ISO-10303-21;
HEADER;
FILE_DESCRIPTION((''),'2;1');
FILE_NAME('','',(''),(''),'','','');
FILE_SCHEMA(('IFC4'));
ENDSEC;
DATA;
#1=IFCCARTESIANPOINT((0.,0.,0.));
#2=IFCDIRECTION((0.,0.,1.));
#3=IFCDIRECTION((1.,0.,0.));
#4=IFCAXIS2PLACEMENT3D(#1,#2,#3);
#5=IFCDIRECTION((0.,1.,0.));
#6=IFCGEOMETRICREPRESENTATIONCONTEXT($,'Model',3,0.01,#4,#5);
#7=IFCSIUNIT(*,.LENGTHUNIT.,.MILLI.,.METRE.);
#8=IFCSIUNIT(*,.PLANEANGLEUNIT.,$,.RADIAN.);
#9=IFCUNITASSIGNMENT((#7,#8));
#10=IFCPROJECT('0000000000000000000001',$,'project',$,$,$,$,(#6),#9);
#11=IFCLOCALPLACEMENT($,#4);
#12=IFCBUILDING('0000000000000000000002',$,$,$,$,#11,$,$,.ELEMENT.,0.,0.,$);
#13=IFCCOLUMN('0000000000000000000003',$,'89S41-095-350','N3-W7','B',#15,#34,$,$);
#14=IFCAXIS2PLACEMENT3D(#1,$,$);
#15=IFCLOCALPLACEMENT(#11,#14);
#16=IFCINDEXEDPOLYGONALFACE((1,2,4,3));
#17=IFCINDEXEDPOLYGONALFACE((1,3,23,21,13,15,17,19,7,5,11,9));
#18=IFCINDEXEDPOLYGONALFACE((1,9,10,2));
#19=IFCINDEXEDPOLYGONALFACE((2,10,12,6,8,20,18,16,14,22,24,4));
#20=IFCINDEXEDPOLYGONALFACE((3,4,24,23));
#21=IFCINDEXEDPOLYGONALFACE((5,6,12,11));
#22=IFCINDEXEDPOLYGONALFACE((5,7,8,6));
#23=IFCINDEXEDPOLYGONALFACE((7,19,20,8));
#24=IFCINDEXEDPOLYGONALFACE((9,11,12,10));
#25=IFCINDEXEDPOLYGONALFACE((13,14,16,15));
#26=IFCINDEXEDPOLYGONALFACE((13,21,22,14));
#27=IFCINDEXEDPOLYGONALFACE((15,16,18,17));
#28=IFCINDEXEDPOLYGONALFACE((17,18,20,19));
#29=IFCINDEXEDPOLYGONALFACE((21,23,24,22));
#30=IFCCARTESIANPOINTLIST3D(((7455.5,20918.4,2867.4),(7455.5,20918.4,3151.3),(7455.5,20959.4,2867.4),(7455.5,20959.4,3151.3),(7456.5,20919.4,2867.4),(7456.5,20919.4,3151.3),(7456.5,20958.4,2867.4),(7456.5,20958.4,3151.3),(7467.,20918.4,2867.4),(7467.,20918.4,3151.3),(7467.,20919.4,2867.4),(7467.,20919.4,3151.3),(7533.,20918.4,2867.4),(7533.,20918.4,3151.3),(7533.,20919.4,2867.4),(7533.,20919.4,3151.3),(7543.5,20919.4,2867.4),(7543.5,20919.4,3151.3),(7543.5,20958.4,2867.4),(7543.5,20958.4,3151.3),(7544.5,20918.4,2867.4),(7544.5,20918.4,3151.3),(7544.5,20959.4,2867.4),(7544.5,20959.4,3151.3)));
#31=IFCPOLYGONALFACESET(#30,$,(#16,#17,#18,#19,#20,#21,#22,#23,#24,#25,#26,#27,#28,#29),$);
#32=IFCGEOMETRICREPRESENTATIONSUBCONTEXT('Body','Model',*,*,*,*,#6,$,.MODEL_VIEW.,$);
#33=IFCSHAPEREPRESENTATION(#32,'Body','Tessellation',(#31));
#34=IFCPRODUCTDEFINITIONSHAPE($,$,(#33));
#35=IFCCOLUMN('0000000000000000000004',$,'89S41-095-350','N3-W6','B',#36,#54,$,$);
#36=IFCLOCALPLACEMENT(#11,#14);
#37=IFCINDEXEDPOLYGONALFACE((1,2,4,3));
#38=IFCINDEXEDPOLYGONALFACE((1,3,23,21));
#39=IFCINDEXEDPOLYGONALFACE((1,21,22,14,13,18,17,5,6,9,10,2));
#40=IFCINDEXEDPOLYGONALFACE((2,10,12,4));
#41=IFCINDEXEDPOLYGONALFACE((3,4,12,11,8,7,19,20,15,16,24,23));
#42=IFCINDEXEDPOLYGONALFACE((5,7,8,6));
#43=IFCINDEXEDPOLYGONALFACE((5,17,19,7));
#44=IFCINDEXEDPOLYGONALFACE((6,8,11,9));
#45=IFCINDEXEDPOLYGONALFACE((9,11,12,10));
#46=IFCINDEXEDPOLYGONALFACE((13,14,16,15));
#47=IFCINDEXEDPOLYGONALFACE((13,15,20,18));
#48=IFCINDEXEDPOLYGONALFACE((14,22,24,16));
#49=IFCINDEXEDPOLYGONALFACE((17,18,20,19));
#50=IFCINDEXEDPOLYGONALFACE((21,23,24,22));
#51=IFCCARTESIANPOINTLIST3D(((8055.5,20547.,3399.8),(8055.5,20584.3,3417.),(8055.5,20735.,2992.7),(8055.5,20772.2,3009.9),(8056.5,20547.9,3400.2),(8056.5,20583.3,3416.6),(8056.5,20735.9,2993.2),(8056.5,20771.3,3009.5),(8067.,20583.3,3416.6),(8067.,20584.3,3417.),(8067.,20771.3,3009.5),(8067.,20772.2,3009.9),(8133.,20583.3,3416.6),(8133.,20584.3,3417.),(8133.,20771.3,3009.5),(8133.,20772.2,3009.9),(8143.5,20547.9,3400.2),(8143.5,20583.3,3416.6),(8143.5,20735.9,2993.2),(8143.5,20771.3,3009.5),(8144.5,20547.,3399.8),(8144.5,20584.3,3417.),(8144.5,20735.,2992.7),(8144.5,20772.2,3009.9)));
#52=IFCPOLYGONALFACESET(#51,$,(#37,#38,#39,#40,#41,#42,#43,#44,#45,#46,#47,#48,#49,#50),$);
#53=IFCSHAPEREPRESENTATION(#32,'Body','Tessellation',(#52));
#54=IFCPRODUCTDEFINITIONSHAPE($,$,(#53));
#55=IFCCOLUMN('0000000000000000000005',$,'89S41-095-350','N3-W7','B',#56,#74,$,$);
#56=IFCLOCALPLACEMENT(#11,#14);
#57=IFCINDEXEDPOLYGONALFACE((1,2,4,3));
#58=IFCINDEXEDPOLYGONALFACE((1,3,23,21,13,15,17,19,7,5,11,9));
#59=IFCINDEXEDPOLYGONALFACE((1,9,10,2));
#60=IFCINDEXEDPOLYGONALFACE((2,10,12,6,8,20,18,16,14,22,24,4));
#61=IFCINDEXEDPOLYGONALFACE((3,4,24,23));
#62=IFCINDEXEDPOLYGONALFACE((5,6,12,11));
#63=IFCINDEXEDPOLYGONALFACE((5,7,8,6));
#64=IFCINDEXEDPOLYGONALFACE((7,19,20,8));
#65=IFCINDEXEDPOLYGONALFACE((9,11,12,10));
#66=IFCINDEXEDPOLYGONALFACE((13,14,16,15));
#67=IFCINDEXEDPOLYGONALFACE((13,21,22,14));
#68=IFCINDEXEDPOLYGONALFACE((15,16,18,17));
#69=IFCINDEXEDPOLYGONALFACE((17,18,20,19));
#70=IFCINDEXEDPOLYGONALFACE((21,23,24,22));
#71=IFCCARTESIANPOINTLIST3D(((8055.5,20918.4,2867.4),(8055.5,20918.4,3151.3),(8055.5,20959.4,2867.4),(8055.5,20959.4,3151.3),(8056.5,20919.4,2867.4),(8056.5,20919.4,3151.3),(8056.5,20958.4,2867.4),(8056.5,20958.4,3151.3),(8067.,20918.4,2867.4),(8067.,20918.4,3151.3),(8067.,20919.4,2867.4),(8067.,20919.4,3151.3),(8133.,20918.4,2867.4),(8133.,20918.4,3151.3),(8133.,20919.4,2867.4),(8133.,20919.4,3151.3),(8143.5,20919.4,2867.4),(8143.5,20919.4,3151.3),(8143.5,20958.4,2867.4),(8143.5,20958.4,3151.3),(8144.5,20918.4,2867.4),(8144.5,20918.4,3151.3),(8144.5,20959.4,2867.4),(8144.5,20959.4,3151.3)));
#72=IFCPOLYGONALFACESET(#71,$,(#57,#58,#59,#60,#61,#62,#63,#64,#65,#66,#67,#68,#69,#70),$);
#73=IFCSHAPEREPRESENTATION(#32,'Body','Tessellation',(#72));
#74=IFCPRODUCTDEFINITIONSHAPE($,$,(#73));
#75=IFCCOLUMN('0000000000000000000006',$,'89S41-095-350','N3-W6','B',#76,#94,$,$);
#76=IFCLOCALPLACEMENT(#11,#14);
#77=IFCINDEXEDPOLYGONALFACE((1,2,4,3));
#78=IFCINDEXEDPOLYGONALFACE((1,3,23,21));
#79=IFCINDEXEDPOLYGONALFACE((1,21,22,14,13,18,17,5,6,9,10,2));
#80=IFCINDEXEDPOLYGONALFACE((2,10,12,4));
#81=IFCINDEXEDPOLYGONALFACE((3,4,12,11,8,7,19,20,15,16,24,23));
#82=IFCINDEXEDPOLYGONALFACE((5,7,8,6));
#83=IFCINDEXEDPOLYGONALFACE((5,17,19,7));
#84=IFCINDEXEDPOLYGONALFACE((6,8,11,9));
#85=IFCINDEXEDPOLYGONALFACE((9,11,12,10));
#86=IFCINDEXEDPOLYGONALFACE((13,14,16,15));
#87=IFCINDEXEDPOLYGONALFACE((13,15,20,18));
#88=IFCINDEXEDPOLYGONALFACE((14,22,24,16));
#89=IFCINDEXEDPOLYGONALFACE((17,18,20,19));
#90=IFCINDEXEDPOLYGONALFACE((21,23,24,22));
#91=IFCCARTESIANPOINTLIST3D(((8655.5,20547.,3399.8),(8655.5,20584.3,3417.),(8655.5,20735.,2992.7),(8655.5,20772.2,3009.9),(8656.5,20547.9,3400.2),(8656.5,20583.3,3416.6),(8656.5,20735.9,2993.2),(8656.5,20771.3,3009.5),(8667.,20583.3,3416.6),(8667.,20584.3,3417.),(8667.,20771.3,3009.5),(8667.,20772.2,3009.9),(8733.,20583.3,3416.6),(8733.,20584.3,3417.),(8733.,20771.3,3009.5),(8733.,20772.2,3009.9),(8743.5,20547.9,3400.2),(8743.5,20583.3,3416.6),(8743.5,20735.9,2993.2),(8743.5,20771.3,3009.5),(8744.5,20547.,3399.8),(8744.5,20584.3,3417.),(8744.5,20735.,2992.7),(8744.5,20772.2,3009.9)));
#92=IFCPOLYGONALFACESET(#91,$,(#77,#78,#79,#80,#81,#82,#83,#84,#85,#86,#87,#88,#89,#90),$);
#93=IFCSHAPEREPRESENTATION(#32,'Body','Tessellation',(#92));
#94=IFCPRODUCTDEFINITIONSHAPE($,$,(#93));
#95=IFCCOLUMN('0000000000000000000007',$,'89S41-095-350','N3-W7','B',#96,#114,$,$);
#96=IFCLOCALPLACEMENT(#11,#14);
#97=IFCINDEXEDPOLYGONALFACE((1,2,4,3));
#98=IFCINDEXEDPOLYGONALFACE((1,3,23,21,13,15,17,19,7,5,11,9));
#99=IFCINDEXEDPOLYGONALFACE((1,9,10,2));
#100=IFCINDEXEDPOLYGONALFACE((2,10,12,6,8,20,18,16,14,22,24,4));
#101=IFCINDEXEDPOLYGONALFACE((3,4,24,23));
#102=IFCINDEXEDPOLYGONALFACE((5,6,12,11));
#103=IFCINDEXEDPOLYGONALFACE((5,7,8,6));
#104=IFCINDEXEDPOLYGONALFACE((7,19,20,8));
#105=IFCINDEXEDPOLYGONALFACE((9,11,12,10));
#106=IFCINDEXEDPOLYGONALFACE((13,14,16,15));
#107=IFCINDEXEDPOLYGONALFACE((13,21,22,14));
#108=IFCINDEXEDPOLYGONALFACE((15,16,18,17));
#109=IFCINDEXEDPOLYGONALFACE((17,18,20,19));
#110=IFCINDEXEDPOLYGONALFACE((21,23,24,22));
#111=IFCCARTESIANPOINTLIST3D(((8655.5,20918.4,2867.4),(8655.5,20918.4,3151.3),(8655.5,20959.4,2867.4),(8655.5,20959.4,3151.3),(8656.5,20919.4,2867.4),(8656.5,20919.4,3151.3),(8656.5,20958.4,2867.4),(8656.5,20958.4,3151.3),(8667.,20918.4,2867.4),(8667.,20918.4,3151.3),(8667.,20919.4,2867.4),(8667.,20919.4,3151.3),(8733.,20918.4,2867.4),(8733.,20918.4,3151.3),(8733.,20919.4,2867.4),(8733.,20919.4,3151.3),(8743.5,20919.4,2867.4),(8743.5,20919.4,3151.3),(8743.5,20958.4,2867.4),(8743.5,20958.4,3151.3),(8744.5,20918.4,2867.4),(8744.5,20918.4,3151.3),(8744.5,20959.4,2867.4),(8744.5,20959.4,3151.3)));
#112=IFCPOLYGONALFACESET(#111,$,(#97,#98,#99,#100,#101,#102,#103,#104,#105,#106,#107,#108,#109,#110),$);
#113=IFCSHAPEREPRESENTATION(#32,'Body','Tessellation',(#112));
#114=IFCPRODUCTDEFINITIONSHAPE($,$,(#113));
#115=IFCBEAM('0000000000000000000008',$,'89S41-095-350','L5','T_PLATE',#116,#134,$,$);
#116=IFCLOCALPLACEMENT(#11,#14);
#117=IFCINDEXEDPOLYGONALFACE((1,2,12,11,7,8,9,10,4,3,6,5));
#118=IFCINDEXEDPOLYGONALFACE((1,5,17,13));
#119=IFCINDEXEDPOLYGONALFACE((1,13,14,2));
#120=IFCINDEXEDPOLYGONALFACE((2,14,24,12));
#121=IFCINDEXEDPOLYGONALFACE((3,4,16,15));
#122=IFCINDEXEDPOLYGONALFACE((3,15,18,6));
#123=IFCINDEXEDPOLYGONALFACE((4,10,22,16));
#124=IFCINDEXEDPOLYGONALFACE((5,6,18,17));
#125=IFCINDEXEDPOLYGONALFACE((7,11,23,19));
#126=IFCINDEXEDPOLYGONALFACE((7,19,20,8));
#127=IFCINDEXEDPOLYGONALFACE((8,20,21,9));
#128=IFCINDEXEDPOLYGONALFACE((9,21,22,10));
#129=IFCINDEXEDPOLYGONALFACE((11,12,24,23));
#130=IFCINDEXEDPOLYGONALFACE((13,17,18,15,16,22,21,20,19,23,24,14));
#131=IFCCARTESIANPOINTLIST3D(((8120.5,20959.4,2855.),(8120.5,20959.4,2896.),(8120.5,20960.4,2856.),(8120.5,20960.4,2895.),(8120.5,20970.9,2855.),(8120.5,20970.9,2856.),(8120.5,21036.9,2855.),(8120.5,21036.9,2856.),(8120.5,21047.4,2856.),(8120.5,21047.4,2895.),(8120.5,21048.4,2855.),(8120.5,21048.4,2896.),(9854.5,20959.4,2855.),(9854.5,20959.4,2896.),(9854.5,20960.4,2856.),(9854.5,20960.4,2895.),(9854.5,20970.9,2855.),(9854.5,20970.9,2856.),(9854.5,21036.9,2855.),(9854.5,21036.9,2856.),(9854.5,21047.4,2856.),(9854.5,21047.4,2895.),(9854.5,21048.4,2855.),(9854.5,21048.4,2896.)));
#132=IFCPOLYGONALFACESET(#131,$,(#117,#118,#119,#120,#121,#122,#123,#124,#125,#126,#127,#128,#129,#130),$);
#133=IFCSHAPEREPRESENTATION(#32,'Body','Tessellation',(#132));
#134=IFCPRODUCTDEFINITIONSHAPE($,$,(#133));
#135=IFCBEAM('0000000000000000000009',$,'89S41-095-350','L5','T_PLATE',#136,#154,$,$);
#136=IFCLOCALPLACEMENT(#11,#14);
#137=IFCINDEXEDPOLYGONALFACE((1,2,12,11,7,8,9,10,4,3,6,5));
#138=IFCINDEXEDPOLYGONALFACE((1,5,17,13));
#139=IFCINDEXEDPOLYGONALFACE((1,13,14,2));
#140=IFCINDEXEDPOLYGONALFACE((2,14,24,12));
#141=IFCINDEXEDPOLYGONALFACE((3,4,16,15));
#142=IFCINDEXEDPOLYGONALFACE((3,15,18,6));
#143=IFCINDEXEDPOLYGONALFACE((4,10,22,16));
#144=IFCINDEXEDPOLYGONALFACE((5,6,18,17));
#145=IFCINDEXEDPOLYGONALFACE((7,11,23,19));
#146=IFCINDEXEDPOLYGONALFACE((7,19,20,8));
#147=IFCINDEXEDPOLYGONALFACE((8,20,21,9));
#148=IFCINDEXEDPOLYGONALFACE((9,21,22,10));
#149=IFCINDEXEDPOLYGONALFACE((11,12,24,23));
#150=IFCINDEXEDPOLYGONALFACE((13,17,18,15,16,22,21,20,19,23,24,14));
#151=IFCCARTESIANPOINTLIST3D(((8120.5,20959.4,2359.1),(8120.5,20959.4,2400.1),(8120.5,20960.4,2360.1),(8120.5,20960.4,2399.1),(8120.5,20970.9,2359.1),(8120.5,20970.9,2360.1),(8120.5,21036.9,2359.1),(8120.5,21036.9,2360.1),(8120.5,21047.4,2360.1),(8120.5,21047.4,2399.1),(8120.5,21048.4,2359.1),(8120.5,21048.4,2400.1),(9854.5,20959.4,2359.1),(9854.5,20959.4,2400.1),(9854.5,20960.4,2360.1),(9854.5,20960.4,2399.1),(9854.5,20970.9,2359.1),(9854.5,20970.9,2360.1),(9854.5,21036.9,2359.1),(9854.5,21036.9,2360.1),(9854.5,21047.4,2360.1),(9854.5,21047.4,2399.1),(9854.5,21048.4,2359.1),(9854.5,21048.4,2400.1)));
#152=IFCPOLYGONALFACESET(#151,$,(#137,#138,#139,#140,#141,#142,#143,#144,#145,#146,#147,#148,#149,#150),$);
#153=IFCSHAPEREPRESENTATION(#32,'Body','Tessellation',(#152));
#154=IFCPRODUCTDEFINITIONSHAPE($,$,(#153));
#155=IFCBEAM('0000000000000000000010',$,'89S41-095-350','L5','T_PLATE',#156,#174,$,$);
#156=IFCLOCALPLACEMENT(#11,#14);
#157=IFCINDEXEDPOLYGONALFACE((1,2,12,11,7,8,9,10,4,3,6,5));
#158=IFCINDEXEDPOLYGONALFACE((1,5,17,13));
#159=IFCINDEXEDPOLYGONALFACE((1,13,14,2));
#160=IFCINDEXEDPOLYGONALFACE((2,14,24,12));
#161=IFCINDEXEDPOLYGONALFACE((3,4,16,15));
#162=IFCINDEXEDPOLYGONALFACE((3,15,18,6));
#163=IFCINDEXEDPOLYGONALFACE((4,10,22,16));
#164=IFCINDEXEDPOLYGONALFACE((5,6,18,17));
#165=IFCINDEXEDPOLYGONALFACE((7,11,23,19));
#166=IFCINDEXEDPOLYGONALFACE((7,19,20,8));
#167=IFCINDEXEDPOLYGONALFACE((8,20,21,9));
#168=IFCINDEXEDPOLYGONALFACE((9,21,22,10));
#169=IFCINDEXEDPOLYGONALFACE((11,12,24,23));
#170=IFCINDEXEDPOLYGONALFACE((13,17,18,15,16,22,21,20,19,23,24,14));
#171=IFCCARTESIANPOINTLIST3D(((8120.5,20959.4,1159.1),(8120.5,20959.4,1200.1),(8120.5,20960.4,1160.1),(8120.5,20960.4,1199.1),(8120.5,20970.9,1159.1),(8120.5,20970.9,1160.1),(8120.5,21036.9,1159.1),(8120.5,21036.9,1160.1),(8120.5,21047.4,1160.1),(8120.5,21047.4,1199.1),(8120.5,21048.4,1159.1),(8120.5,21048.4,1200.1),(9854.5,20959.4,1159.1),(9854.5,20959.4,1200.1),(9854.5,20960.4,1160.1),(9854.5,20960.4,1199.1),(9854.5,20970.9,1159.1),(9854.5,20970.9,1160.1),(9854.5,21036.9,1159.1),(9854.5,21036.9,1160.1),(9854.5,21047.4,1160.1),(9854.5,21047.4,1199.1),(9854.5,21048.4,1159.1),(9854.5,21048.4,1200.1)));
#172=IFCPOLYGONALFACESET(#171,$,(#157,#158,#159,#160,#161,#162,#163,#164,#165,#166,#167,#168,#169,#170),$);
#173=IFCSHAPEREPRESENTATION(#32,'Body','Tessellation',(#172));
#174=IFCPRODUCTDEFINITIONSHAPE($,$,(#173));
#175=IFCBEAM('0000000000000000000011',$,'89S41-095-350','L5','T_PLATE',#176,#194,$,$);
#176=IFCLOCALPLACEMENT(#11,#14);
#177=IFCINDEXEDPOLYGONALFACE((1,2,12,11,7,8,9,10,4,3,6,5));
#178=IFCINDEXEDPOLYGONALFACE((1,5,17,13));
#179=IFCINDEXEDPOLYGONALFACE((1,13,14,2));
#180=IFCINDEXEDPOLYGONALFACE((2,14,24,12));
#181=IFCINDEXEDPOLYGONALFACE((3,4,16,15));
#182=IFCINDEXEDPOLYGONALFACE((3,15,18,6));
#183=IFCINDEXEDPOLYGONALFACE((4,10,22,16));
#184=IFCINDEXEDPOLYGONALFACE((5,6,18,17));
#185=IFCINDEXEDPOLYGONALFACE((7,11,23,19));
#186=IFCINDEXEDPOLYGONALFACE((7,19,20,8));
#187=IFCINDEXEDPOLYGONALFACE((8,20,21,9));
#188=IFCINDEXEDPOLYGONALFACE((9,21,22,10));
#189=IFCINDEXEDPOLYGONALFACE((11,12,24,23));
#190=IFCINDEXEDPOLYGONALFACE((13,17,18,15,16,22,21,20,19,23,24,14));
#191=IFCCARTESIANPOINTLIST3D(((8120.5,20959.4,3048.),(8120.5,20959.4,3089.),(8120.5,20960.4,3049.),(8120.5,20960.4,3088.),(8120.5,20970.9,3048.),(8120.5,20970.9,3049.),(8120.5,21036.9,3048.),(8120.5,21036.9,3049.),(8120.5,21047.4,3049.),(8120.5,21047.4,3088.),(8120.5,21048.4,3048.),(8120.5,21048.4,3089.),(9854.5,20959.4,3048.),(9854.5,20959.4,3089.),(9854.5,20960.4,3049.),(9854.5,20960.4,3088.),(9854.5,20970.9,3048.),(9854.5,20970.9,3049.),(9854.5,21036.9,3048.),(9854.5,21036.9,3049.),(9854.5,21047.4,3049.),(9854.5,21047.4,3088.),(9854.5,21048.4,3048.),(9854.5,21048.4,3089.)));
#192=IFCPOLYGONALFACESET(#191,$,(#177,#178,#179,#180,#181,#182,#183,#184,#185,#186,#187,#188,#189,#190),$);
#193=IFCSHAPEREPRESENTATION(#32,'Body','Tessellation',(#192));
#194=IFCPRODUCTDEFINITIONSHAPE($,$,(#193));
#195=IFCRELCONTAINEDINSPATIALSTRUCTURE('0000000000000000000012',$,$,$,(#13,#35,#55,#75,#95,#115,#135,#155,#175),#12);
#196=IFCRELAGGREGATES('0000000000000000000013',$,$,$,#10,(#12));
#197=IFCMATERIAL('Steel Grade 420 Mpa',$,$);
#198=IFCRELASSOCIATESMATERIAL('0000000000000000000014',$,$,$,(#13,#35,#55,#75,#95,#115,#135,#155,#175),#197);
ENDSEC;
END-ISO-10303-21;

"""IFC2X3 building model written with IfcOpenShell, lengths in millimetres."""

from ifc_helpers import new_model, si_unit, direction, frame, origin, origin_with_axes, origin_2d_with_axis, place, context, subcontext, project, spatial, c_section, extrude, source, transform, mapped, material, element, save


model = new_model("IFC2X3")

# Units and contexts
model_context = context("Model", 3, precision=0.01, world=origin_with_axes(), true_north=direction((0.0, 1.0, 0.0)))
body_context = subcontext(model_context, "Body", "Model", "MODEL_VIEW")
ifc_project = project(units=[si_unit("LENGTHUNIT", "METRE", prefix="MILLI"), si_unit("PLANEANGLEUNIT", "RADIAN")], contexts=[model_context])

# Building
building_placement = place(None, origin_with_axes())
building = spatial("IfcBuilding", under=ifc_project, at=building_placement, CompositionType="ELEMENT", ElevationOfRefHeight=0.0, ElevationOfTerrain=0.0)

# Columns
ifc_material = material(Name="Steel Grade 420 Mpa")
shared_shape_1 = source(origin(), body_context, "Body", "SweptSolid", [
    extrude(c_section(Depth=89.0, Width=41.0, WallThickness=1.0, Girth=11.5, at=origin_2d_with_axis()), origin_with_axes(), (0.0, 0.0, 1.0), 283.9),
])
column_1_placement = place(None, frame((7500.0, 20938.9, 3151.3), z_axis=(0.0, 0.0, -1.0), x_axis=(0.0, -1.0, 0.0)))
element("IfcColumn", 1, at=column_1_placement, inside=building, material=ifc_material, Name="89S41-095-350", Description="N3-W7", ObjectType="B", context=body_context, shape_type="MappedRepresentation", body=[
    mapped(shared_shape_1, transform((0.0, 0.0, 0.0), scale=1.0)),
])
shared_shape_2 = source(origin(), body_context, "Body", "SweptSolid", [
    extrude(c_section(Depth=89.0, Width=41.0, WallThickness=1.0, Girth=11.5, at=origin_2d_with_axis()), origin_with_axes(), (0.0, 0.0, 1.0), 448.4),
])
column_2_placement = place(None, frame((8100.0, 20753.6, 3001.3), z_axis=(0.0, -0.419234, 0.907878), x_axis=(0.0, 0.907878, 0.419234)))
element("IfcColumn", 2, at=column_2_placement, inside=building, material=ifc_material, Name="89S41-095-350", Description="N3-W6", ObjectType="B", context=body_context, shape_type="MappedRepresentation", body=[
    mapped(shared_shape_2, transform((0.0, 0.0, 0.0), scale=1.0)),
])
shared_shape_3 = source(origin(), body_context, "Body", "SweptSolid", [
    extrude(c_section(Depth=89.0, Width=41.0, WallThickness=1.0, Girth=11.5, at=origin_2d_with_axis()), origin_with_axes(), (0.0, 0.0, 1.0), 283.9),
])
column_3_placement = place(None, frame((8100.0, 20938.9, 3151.3), z_axis=(0.0, 0.0, -1.0), x_axis=(0.0, -1.0, 0.0)))
element("IfcColumn", 3, at=column_3_placement, inside=building, material=ifc_material, Name="89S41-095-350", Description="N3-W7", ObjectType="B", context=body_context, shape_type="MappedRepresentation", body=[
    mapped(shared_shape_3, transform((0.0, 0.0, 0.0), scale=1.0)),
])
shared_shape_4 = source(origin(), body_context, "Body", "SweptSolid", [
    extrude(c_section(Depth=89.0, Width=41.0, WallThickness=1.0, Girth=11.5, at=origin_2d_with_axis()), origin_with_axes(), (0.0, 0.0, 1.0), 448.4),
])
column_4_placement = place(None, frame((8700.0, 20753.6, 3001.3), z_axis=(0.0, -0.419234, 0.907878), x_axis=(0.0, 0.907878, 0.419234)))
element("IfcColumn", 4, at=column_4_placement, inside=building, material=ifc_material, Name="89S41-095-350", Description="N3-W6", ObjectType="B", context=body_context, shape_type="MappedRepresentation", body=[
    mapped(shared_shape_4, transform((0.0, 0.0, 0.0), scale=1.0)),
])
shared_shape_5 = source(origin(), body_context, "Body", "SweptSolid", [
    extrude(c_section(Depth=89.0, Width=41.0, WallThickness=1.0, Girth=11.5, at=origin_2d_with_axis()), origin_with_axes(), (0.0, 0.0, 1.0), 283.9),
])
column_5_placement = place(None, frame((8700.0, 20938.9, 3151.3), z_axis=(0.0, 0.0, -1.0), x_axis=(0.0, -1.0, 0.0)))
element("IfcColumn", 5, at=column_5_placement, inside=building, material=ifc_material, Name="89S41-095-350", Description="N3-W7", ObjectType="B", context=body_context, shape_type="MappedRepresentation", body=[
    mapped(shared_shape_5, transform((0.0, 0.0, 0.0), scale=1.0)),
])

# Beams
shared_shape_6 = source(origin(), body_context, "Body", "SweptSolid", [
    extrude(c_section(Depth=89.0, Width=41.0, WallThickness=1.0, Girth=11.5, at=origin_2d_with_axis()), origin_with_axes(), (0.0, 0.0, 1.0), 1734.0),
])
beam_1_placement = place(None, frame((8120.5, 21003.9, 2875.5), z_axis=(1.0, 0.0, 0.0), x_axis=(0.0, 0.0, -1.0)))
element("IfcBeam", 6, at=beam_1_placement, inside=building, material=ifc_material, Name="89S41-095-350", Description="L5", ObjectType="T_PLATE", context=body_context, shape_type="MappedRepresentation", body=[
    mapped(shared_shape_6, transform((0.0, 0.0, 0.0), scale=1.0)),
])
shared_shape_7 = source(origin(), body_context, "Body", "SweptSolid", [
    extrude(c_section(Depth=89.0, Width=41.0, WallThickness=1.0, Girth=11.5, at=origin_2d_with_axis()), origin_with_axes(), (0.0, 0.0, 1.0), 1734.0),
])
beam_2_placement = place(None, frame((8120.5, 21003.9, 2379.6), z_axis=(1.0, 0.0, 0.0), x_axis=(0.0, 0.0, -1.0)))
element("IfcBeam", 7, at=beam_2_placement, inside=building, material=ifc_material, Name="89S41-095-350", Description="L5", ObjectType="T_PLATE", context=body_context, shape_type="MappedRepresentation", body=[
    mapped(shared_shape_7, transform((0.0, 0.0, 0.0), scale=1.0)),
])
shared_shape_8 = source(origin(), body_context, "Body", "SweptSolid", [
    extrude(c_section(Depth=89.0, Width=41.0, WallThickness=1.0, Girth=11.5, at=origin_2d_with_axis()), origin_with_axes(), (0.0, 0.0, 1.0), 1734.0),
])
beam_3_placement = place(None, frame((8120.5, 21003.9, 1179.6), z_axis=(1.0, 0.0, 0.0), x_axis=(0.0, 0.0, -1.0)))
element("IfcBeam", 8, at=beam_3_placement, inside=building, material=ifc_material, Name="89S41-095-350", Description="L5", ObjectType="T_PLATE", context=body_context, shape_type="MappedRepresentation", body=[
    mapped(shared_shape_8, transform((0.0, 0.0, 0.0), scale=1.0)),
])
shared_shape_9 = source(origin(), body_context, "Body", "SweptSolid", [
    extrude(c_section(Depth=89.0, Width=41.0, WallThickness=1.0, Girth=11.5, at=origin_2d_with_axis()), origin_with_axes(), (0.0, 0.0, 1.0), 1734.0),
])
beam_4_placement = place(None, frame((8120.5, 21003.9, 3068.5), z_axis=(1.0, 0.0, 0.0), x_axis=(0.0, 0.0, -1.0)))
element("IfcBeam", 9, at=beam_4_placement, inside=building, material=ifc_material, Name="89S41-095-350", Description="L5", ObjectType="T_PLATE", context=body_context, shape_type="MappedRepresentation", body=[
    mapped(shared_shape_9, transform((0.0, 0.0, 0.0), scale=1.0)),
])

save(model, "model.ifc")
